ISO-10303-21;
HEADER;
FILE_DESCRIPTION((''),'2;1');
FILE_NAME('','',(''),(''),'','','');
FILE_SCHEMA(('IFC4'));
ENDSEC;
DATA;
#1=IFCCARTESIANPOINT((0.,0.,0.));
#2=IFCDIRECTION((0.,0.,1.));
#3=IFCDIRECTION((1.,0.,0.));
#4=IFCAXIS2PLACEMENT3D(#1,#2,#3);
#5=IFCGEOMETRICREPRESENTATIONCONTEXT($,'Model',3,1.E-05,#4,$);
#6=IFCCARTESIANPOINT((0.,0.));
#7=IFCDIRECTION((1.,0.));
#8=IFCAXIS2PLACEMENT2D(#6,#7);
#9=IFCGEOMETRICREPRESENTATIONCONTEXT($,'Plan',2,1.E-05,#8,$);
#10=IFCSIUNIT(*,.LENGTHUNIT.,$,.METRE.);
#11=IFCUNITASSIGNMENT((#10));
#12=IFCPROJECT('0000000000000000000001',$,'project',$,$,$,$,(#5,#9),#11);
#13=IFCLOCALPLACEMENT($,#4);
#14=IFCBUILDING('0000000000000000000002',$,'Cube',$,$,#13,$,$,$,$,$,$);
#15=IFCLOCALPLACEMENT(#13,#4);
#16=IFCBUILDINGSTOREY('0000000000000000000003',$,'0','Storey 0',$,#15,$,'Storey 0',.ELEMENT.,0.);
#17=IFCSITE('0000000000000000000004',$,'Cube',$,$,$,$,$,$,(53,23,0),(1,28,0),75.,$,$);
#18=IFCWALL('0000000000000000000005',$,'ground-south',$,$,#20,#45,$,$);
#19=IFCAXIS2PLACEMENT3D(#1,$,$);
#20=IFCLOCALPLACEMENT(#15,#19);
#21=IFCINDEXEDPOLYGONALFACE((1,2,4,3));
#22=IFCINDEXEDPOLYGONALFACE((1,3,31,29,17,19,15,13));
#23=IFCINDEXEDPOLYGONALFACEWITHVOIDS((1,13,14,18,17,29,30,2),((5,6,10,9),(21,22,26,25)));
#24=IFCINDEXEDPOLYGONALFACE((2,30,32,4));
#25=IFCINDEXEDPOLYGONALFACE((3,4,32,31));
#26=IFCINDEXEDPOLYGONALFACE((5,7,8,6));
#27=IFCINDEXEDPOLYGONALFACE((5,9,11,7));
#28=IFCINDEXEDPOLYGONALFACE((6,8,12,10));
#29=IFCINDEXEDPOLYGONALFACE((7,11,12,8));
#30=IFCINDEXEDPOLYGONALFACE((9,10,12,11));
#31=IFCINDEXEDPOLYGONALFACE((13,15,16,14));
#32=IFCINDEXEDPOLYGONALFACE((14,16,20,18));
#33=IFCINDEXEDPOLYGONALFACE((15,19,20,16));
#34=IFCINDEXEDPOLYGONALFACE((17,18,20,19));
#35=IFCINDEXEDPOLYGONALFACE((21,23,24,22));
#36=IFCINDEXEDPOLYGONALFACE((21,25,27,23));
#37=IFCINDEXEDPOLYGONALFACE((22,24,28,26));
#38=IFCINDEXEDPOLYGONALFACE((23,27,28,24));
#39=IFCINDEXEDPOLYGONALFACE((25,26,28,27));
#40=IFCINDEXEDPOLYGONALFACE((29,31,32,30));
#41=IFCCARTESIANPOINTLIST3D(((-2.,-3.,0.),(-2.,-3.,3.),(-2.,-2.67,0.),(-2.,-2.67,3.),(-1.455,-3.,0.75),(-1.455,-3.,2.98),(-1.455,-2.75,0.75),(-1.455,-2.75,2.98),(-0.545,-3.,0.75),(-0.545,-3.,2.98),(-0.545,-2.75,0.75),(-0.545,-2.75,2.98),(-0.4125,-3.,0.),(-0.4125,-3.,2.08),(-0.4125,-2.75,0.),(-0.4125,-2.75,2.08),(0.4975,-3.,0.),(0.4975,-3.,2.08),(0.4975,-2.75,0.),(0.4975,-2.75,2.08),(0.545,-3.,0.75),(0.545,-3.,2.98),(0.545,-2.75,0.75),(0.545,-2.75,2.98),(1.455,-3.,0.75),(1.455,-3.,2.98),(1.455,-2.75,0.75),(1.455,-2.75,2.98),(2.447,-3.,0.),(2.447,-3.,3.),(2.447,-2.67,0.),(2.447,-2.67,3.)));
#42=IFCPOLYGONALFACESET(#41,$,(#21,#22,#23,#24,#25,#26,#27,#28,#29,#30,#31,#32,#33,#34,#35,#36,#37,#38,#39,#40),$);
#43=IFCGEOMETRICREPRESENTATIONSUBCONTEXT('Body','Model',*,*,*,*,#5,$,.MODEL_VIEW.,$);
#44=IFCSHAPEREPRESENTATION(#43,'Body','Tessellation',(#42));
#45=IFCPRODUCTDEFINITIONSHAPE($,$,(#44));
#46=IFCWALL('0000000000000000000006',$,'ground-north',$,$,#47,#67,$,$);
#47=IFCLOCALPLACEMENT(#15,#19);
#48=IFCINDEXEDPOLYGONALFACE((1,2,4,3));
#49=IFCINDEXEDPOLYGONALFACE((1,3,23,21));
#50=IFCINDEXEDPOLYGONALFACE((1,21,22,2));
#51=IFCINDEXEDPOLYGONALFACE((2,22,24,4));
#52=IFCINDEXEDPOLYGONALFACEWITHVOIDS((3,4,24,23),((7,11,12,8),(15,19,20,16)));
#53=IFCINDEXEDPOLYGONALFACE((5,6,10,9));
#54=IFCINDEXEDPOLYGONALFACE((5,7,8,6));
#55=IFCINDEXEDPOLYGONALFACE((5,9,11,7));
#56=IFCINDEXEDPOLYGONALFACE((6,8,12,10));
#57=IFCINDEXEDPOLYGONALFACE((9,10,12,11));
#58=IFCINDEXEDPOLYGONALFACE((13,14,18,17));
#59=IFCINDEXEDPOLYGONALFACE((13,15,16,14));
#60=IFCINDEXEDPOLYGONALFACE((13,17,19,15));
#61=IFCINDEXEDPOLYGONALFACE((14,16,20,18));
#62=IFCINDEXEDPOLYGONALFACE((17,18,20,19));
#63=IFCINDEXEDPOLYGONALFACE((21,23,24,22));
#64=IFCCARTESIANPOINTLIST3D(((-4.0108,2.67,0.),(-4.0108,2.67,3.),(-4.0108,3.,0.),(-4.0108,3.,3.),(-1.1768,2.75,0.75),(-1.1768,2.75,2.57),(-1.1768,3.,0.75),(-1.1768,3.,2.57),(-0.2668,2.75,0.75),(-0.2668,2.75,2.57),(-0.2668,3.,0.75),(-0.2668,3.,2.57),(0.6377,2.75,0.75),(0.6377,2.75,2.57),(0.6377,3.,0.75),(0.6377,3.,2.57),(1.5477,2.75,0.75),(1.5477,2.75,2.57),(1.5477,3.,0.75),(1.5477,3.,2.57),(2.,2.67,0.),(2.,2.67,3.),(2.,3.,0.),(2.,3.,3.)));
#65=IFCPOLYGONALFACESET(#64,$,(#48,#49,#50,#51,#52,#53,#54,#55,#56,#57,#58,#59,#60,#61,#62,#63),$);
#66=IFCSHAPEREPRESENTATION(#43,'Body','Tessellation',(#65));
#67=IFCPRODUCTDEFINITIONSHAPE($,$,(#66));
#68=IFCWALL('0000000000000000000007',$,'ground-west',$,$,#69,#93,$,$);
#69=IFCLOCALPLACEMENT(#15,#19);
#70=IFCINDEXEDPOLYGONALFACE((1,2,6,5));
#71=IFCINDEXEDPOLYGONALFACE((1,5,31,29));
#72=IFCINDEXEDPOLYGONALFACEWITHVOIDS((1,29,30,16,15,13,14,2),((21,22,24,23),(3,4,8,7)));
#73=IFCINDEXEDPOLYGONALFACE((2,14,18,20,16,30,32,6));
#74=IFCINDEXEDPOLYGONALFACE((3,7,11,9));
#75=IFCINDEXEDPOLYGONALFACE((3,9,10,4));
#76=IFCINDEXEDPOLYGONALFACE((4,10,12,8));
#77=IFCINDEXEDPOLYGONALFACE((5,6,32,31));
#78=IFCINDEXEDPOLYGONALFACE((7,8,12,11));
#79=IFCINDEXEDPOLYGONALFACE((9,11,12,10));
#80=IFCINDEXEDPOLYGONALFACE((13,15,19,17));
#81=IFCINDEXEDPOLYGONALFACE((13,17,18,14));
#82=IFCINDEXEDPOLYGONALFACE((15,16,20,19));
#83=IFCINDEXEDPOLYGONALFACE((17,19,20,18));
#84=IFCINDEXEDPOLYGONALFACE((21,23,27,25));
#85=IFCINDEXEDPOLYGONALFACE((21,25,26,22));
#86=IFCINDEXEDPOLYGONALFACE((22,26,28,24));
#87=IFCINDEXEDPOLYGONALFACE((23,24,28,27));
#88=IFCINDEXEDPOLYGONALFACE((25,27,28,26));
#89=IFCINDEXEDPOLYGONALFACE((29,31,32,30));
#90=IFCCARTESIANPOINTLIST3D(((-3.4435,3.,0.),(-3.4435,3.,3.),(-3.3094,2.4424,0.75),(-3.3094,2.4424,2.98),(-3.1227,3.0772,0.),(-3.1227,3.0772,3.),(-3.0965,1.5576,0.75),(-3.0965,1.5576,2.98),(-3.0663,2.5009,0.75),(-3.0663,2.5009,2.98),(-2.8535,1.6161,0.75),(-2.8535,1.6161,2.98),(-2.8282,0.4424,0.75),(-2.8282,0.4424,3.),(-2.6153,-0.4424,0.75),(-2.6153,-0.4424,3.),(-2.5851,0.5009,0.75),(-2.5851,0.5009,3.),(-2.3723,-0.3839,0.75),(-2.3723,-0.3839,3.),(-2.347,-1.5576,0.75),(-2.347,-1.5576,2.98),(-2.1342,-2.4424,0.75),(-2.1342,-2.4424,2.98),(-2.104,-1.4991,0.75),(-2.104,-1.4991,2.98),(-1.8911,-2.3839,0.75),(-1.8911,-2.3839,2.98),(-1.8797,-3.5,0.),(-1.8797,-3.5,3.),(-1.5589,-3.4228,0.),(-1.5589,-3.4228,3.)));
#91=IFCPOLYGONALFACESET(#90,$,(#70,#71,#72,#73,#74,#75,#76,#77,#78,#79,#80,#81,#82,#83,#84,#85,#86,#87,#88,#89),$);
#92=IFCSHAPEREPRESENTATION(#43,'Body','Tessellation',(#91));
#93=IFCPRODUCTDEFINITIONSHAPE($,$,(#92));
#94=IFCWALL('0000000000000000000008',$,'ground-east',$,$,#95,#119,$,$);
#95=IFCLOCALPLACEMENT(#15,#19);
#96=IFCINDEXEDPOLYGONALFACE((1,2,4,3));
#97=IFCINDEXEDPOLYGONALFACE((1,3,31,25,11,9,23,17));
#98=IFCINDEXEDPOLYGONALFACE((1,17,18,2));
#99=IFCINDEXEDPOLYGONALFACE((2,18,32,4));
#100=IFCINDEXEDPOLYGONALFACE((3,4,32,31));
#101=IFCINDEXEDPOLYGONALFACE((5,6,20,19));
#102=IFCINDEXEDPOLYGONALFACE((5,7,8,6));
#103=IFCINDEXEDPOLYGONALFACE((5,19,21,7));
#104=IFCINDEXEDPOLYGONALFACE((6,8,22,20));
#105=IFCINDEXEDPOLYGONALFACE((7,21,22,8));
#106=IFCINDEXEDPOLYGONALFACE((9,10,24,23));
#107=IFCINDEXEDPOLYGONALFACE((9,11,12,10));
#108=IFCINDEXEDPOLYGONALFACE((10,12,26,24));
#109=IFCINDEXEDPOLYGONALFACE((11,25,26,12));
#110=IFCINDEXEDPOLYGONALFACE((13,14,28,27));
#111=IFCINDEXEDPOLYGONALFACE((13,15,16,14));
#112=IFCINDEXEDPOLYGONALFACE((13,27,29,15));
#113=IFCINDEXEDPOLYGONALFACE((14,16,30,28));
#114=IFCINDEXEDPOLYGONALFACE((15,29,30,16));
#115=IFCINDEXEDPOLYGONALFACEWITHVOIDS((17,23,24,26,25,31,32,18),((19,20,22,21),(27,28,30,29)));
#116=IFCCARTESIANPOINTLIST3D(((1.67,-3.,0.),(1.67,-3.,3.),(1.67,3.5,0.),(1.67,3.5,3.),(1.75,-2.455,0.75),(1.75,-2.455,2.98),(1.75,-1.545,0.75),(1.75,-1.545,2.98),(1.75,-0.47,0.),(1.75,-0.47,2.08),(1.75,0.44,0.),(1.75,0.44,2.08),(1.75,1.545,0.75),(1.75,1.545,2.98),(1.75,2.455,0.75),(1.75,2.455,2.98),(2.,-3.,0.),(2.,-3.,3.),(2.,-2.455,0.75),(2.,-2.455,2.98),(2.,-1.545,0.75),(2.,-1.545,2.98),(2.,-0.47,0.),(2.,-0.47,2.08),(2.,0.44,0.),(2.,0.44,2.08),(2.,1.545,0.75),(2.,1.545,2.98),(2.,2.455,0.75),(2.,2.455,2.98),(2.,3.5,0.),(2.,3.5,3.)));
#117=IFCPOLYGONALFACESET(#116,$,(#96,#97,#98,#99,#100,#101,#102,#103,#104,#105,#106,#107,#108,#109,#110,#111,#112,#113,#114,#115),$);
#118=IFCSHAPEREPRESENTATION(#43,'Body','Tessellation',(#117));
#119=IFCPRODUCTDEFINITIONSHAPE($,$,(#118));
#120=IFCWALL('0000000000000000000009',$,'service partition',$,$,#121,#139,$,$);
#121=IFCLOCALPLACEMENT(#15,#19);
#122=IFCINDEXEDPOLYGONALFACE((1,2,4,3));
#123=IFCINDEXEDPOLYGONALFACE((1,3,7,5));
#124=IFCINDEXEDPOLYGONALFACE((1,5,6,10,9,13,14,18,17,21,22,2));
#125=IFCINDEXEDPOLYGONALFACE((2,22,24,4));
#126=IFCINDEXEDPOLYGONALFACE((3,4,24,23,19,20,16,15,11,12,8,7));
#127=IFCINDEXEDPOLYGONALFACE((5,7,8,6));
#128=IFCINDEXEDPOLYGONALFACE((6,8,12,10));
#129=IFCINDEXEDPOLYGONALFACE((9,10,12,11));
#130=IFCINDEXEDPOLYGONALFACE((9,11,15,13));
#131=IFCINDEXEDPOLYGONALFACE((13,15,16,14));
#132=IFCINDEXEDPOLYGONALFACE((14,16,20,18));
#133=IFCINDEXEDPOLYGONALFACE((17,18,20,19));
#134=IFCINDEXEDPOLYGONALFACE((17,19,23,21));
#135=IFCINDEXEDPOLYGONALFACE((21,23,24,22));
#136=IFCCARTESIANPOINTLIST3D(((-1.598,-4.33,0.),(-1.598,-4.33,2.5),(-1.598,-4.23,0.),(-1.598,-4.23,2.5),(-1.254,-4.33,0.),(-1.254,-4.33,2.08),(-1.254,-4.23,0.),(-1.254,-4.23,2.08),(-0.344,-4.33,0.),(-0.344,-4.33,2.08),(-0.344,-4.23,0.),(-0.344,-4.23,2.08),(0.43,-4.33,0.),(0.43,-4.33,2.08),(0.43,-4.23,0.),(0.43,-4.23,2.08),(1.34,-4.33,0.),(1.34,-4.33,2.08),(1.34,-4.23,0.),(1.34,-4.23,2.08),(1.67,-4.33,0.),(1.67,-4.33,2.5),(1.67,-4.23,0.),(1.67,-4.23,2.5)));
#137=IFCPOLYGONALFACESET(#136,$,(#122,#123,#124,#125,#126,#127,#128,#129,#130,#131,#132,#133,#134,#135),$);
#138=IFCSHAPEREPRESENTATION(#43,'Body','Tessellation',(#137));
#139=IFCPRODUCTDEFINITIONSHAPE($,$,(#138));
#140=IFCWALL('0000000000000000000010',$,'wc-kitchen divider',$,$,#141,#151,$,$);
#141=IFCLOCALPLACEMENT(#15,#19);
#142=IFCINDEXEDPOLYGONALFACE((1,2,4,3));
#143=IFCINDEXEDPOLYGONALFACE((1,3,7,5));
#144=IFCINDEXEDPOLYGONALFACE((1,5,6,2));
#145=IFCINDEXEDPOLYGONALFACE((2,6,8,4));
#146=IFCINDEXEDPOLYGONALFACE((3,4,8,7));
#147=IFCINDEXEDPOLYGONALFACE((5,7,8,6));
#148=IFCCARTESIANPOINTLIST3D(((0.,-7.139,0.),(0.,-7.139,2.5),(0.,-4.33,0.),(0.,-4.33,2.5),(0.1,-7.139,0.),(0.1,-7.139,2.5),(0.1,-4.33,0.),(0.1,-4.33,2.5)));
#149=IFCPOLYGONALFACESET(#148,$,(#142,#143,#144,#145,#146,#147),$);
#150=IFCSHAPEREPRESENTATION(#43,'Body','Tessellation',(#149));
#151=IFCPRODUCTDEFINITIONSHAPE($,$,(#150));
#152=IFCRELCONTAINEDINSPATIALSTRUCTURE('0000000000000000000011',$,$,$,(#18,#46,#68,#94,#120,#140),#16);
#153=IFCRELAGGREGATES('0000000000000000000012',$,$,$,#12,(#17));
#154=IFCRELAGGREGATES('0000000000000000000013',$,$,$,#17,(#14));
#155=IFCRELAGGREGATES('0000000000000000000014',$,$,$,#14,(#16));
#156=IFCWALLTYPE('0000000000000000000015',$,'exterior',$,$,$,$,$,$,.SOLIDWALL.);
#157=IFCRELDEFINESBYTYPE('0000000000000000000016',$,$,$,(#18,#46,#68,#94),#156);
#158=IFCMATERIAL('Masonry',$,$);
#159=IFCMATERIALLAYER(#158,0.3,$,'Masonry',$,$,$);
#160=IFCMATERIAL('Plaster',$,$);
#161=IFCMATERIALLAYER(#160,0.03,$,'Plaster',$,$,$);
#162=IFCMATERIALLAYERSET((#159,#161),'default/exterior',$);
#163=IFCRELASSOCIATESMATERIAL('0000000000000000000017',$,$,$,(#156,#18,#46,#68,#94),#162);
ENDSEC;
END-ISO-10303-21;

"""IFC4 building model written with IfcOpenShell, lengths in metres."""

from ifc_helpers import new_model, si_unit, frame, origin_with_axes, origin_2d_with_axis, place, context, subcontext, project, spatial, indexed_curve, outline, extrude, material, layer, layer_set, layer_usage, type_object, element, save


model = new_model("IFC4")

# Units and contexts
model_context = context("Model", 3, precision=1e-05, world=origin_with_axes())
plan_context = context("Plan", 2, precision=1e-05, world=origin_2d_with_axis())
body_context = subcontext(model_context, "Body", "Model", "MODEL_VIEW")
ifc_project = project(units=[si_unit("LENGTHUNIT", "METRE")], contexts=[model_context, plan_context])

# Site, building, storey
site = spatial("IfcSite", under=ifc_project, Name="Cube", RefLatitude=(53, 23, 0), RefLongitude=(1, 28, 0), RefElevation=75.0)
building_placement = place(None, origin_with_axes())
building = spatial("IfcBuilding", under=site, at=building_placement, Name="Cube")
storey_placement = place(building_placement, origin_with_axes())
storey = spatial("IfcBuildingStorey", under=building, at=storey_placement, Name="0", Description="Storey 0", LongName="Storey 0", CompositionType="ELEMENT", Elevation=0.0)

# Shared definitions
ifc_material_1 = material(Name="Masonry")
ifc_layer_1 = layer(ifc_material_1, 0.3, Name="Masonry")
ifc_material_2 = material(Name="Plaster")
ifc_layer_2 = layer(ifc_material_2, 0.03, Name="Plaster")
ifc_layer_set_1 = layer_set([ifc_layer_1, ifc_layer_2], Name="default/exterior")
wall_type = type_object("IfcWallType", Name="exterior", PredefinedType="SOLIDWALL", material=ifc_layer_set_1)

# Walls, openings
ifc_layer_usage_1 = layer_usage(ifc_layer_set_1, "AXIS2", "POSITIVE", 0.0)
wall_1_placement = place(storey_placement, frame((-2.0, -3.0, 0.0), z_axis=(0.0, 0.0, 1.0), x_axis=(1.0, 0.0, 0.0)))
wall_1 = element("IfcWall", 1, at=wall_1_placement, inside=storey, type_object=wall_type, material=ifc_layer_usage_1, Name="ground-south", context=body_context, shape_type="SweptSolid", body=[
    extrude(outline(indexed_curve([(0.0, 0.0), (0.0, 0.33), (4.447, 0.33), (4.447, 0.0), (0.0, 0.0)], self_intersect=False)), origin_with_axes(), (0.0, 0.0, 1.0), 3.0),
])
opening_1_placement = place(wall_1_placement, frame((0.545, -0.25, 0.75), z_axis=(0.0, 0.0, 1.0), x_axis=(1.0, 0.0, 0.0)))
element("IfcOpeningElement", 2, at=opening_1_placement, cuts=wall_1, PredefinedType="OPENING", context=body_context, shape_type="SweptSolid", body=[
    extrude(outline(indexed_curve([(0.0, 0.0), (0.0, 0.5), (0.91, 0.5), (0.91, 0.0), (0.0, 0.0)], self_intersect=False)), origin_with_axes(), (0.0, 0.0, 1.0), 2.23),
])
opening_2_placement = place(wall_1_placement, frame((2.545, -0.25, 0.75), z_axis=(0.0, 0.0, 1.0), x_axis=(1.0, 0.0, 0.0)))
element("IfcOpeningElement", 3, at=opening_2_placement, cuts=wall_1, PredefinedType="OPENING", context=body_context, shape_type="SweptSolid", body=[
    extrude(outline(indexed_curve([(0.0, 0.0), (0.0, 0.5), (0.91, 0.5), (0.91, 0.0), (0.0, 0.0)], self_intersect=False)), origin_with_axes(), (0.0, 0.0, 1.0), 2.23),
])
opening_3_placement = place(wall_1_placement, frame((1.5875, -0.25, 0.0), z_axis=(0.0, 0.0, 1.0), x_axis=(1.0, 0.0, 0.0)))
element("IfcOpeningElement", 4, at=opening_3_placement, cuts=wall_1, PredefinedType="OPENING", context=body_context, shape_type="SweptSolid", body=[
    extrude(outline(indexed_curve([(0.0, 0.0), (0.0, 0.5), (0.91, 0.5), (0.91, 0.0), (0.0, 0.0)], self_intersect=False)), origin_with_axes(), (0.0, 0.0, 1.0), 2.08),
])
ifc_layer_usage_2 = layer_usage(ifc_layer_set_1, "AXIS2", "POSITIVE", 0.0)
wall_2_placement = place(storey_placement, frame((2.0, 3.0, 0.0), z_axis=(0.0, 0.0, 1.0), x_axis=(-1.0, 0.0, 0.0)))
wall_2 = element("IfcWall", 5, at=wall_2_placement, inside=storey, type_object=wall_type, material=ifc_layer_usage_2, Name="ground-north", context=body_context, shape_type="SweptSolid", body=[
    extrude(outline(indexed_curve([(0.0, 0.0), (0.0, 0.33), (6.0108, 0.33), (6.0108, 0.0), (0.0, 0.0)], self_intersect=False)), origin_with_axes(), (0.0, 0.0, 1.0), 3.0),
])
opening_4_placement = place(wall_2_placement, frame((2.2668, -0.25, 0.75), z_axis=(0.0, 0.0, 1.0), x_axis=(1.0, 0.0, 0.0)))
element("IfcOpeningElement", 6, at=opening_4_placement, cuts=wall_2, PredefinedType="OPENING", context=body_context, shape_type="SweptSolid", body=[
    extrude(outline(indexed_curve([(0.0, 0.0), (0.0, 0.5), (0.91, 0.5), (0.91, 0.0), (0.0, 0.0)], self_intersect=False)), origin_with_axes(), (0.0, 0.0, 1.0), 1.82),
])
opening_5_placement = place(wall_2_placement, frame((0.4523, -0.25, 0.75), z_axis=(0.0, 0.0, 1.0), x_axis=(1.0, 0.0, 0.0)))
element("IfcOpeningElement", 7, at=opening_5_placement, cuts=wall_2, PredefinedType="OPENING", context=body_context, shape_type="SweptSolid", body=[
    extrude(outline(indexed_curve([(0.0, 0.0), (0.0, 0.5), (0.91, 0.5), (0.91, 0.0), (0.0, 0.0)], self_intersect=False)), origin_with_axes(), (0.0, 0.0, 1.0), 1.82),
])
ifc_layer_usage_3 = layer_usage(ifc_layer_set_1, "AXIS2", "POSITIVE", 0.0)
wall_3_placement = place(storey_placement, frame((-3.4435, 3.0, 0.0), z_axis=(0.0, 0.0, 1.0), x_axis=(0.233915, -0.972257, 0.0)))
wall_3 = element("IfcWall", 8, at=wall_3_placement, inside=storey, type_object=wall_type, material=ifc_layer_usage_3, Name="ground-west", context=body_context, shape_type="SweptSolid", body=[
    extrude(outline(indexed_curve([(0.0, 0.0), (0.0, 0.33), (6.6855, 0.33), (6.6855, 0.0), (0.0, 0.0)], self_intersect=False)), origin_with_axes(), (0.0, 0.0, 1.0), 3.0),
])
opening_6_placement = place(wall_3_placement, frame((0.5735, -0.25, 0.75), z_axis=(0.0, 0.0, 1.0), x_axis=(1.0, 0.0, 0.0)))
element("IfcOpeningElement", 9, at=opening_6_placement, cuts=wall_3, PredefinedType="OPENING", context=body_context, shape_type="SweptSolid", body=[
    extrude(outline(indexed_curve([(0.0, 0.0), (0.0, 0.5), (0.91, 0.5), (0.91, 0.0), (0.0, 0.0)], self_intersect=False)), origin_with_axes(), (0.0, 0.0, 1.0), 2.23),
])
opening_7_placement = place(wall_3_placement, frame((2.6306, -0.25, 0.75), z_axis=(0.0, 0.0, 1.0), x_axis=(1.0, 0.0, 0.0)))
element("IfcOpeningElement", 10, at=opening_7_placement, cuts=wall_3, PredefinedType="OPENING", context=body_context, shape_type="SweptSolid", body=[
    extrude(outline(indexed_curve([(0.0, 0.0), (0.0, 0.5), (0.91, 0.5), (0.91, 0.0), (0.0, 0.0)], self_intersect=False)), origin_with_axes(), (0.0, 0.0, 1.0), 2.65),
])
opening_8_placement = place(wall_3_placement, frame((4.6877, -0.25, 0.75), z_axis=(0.0, 0.0, 1.0), x_axis=(1.0, 0.0, 0.0)))
element("IfcOpeningElement", 11, at=opening_8_placement, cuts=wall_3, PredefinedType="OPENING", context=body_context, shape_type="SweptSolid", body=[
    extrude(outline(indexed_curve([(0.0, 0.0), (0.0, 0.5), (0.91, 0.5), (0.91, 0.0), (0.0, 0.0)], self_intersect=False)), origin_with_axes(), (0.0, 0.0, 1.0), 2.23),
])
ifc_layer_usage_4 = layer_usage(ifc_layer_set_1, "AXIS2", "POSITIVE", 0.0)
wall_4_placement = place(storey_placement, frame((2.0, -3.0, 0.0), z_axis=(0.0, 0.0, 1.0), x_axis=(0.0, 1.0, 0.0)))
wall_4 = element("IfcWall", 12, at=wall_4_placement, inside=storey, type_object=wall_type, material=ifc_layer_usage_4, Name="ground-east", context=body_context, shape_type="SweptSolid", body=[
    extrude(outline(indexed_curve([(0.0, 0.0), (0.0, 0.33), (6.5, 0.33), (6.5, 0.0), (0.0, 0.0)], self_intersect=False)), origin_with_axes(), (0.0, 0.0, 1.0), 3.0),
])
opening_9_placement = place(wall_4_placement, frame((2.53, -0.25, 0.0), z_axis=(0.0, 0.0, 1.0), x_axis=(1.0, 0.0, 0.0)))
element("IfcOpeningElement", 13, at=opening_9_placement, cuts=wall_4, PredefinedType="OPENING", context=body_context, shape_type="SweptSolid", body=[
    extrude(outline(indexed_curve([(0.0, 0.0), (0.0, 0.5), (0.91, 0.5), (0.91, 0.0), (0.0, 0.0)], self_intersect=False)), origin_with_axes(), (0.0, 0.0, 1.0), 2.08),
])
opening_10_placement = place(wall_4_placement, frame((0.545, -0.25, 0.75), z_axis=(0.0, 0.0, 1.0), x_axis=(1.0, 0.0, 0.0)))
element("IfcOpeningElement", 14, at=opening_10_placement, cuts=wall_4, PredefinedType="OPENING", context=body_context, shape_type="SweptSolid", body=[
    extrude(outline(indexed_curve([(0.0, 0.0), (0.0, 0.5), (0.91, 0.5), (0.91, 0.0), (0.0, 0.0)], self_intersect=False)), origin_with_axes(), (0.0, 0.0, 1.0), 2.23),
])
opening_11_placement = place(wall_4_placement, frame((4.545, -0.25, 0.75), z_axis=(0.0, 0.0, 1.0), x_axis=(1.0, 0.0, 0.0)))
element("IfcOpeningElement", 15, at=opening_11_placement, cuts=wall_4, PredefinedType="OPENING", context=body_context, shape_type="SweptSolid", body=[
    extrude(outline(indexed_curve([(0.0, 0.0), (0.0, 0.5), (0.91, 0.5), (0.91, 0.0), (0.0, 0.0)], self_intersect=False)), origin_with_axes(), (0.0, 0.0, 1.0), 2.23),
])
wall_5_placement = place(storey_placement, frame((-1.598, -4.33, 0.0), z_axis=(0.0, 0.0, 1.0), x_axis=(1.0, 0.0, 0.0)))
wall_5 = element("IfcWall", 16, at=wall_5_placement, inside=storey, Name="service partition", context=body_context, shape_type="SweptSolid", body=[
    extrude(outline(indexed_curve([(0.0, 0.0), (0.0, 0.1), (3.268, 0.1), (3.268, 0.0), (0.0, 0.0)], self_intersect=False)), origin_with_axes(), (0.0, 0.0, 1.0), 2.5),
])
opening_12_placement = place(wall_5_placement, frame((0.344, -0.05, 0.0), z_axis=(0.0, 0.0, 1.0), x_axis=(1.0, 0.0, 0.0)))
element("IfcOpeningElement", 17, at=opening_12_placement, cuts=wall_5, context=body_context, shape_type="SweptSolid", body=[
    extrude(outline(indexed_curve([(0.0, 0.0), (0.0, 0.3), (0.91, 0.3), (0.91, 0.0), (0.0, 0.0)], self_intersect=False)), origin_with_axes(), (0.0, 0.0, 1.0), 2.08),
])
opening_13_placement = place(wall_5_placement, frame((2.028, -0.05, 0.0), z_axis=(0.0, 0.0, 1.0), x_axis=(1.0, 0.0, 0.0)))
element("IfcOpeningElement", 18, at=opening_13_placement, cuts=wall_5, context=body_context, shape_type="SweptSolid", body=[
    extrude(outline(indexed_curve([(0.0, 0.0), (0.0, 0.3), (0.91, 0.3), (0.91, 0.0), (0.0, 0.0)], self_intersect=False)), origin_with_axes(), (0.0, 0.0, 1.0), 2.08),
])

# Wall
wall_6_placement = place(storey_placement, frame((0.0, -4.33, 0.0), z_axis=(0.0, 0.0, 1.0), x_axis=(0.0, -1.0, 0.0)))
element("IfcWall", 19, at=wall_6_placement, inside=storey, Name="wc-kitchen divider", context=body_context, shape_type="SweptSolid", body=[
    extrude(outline(indexed_curve([(0.0, 0.0), (0.0, 0.1), (2.809, 0.1), (2.809, 0.0), (0.0, 0.0)], self_intersect=False)), origin_with_axes(), (0.0, 0.0, 1.0), 2.5),
])

save(model, "model.ifc")
